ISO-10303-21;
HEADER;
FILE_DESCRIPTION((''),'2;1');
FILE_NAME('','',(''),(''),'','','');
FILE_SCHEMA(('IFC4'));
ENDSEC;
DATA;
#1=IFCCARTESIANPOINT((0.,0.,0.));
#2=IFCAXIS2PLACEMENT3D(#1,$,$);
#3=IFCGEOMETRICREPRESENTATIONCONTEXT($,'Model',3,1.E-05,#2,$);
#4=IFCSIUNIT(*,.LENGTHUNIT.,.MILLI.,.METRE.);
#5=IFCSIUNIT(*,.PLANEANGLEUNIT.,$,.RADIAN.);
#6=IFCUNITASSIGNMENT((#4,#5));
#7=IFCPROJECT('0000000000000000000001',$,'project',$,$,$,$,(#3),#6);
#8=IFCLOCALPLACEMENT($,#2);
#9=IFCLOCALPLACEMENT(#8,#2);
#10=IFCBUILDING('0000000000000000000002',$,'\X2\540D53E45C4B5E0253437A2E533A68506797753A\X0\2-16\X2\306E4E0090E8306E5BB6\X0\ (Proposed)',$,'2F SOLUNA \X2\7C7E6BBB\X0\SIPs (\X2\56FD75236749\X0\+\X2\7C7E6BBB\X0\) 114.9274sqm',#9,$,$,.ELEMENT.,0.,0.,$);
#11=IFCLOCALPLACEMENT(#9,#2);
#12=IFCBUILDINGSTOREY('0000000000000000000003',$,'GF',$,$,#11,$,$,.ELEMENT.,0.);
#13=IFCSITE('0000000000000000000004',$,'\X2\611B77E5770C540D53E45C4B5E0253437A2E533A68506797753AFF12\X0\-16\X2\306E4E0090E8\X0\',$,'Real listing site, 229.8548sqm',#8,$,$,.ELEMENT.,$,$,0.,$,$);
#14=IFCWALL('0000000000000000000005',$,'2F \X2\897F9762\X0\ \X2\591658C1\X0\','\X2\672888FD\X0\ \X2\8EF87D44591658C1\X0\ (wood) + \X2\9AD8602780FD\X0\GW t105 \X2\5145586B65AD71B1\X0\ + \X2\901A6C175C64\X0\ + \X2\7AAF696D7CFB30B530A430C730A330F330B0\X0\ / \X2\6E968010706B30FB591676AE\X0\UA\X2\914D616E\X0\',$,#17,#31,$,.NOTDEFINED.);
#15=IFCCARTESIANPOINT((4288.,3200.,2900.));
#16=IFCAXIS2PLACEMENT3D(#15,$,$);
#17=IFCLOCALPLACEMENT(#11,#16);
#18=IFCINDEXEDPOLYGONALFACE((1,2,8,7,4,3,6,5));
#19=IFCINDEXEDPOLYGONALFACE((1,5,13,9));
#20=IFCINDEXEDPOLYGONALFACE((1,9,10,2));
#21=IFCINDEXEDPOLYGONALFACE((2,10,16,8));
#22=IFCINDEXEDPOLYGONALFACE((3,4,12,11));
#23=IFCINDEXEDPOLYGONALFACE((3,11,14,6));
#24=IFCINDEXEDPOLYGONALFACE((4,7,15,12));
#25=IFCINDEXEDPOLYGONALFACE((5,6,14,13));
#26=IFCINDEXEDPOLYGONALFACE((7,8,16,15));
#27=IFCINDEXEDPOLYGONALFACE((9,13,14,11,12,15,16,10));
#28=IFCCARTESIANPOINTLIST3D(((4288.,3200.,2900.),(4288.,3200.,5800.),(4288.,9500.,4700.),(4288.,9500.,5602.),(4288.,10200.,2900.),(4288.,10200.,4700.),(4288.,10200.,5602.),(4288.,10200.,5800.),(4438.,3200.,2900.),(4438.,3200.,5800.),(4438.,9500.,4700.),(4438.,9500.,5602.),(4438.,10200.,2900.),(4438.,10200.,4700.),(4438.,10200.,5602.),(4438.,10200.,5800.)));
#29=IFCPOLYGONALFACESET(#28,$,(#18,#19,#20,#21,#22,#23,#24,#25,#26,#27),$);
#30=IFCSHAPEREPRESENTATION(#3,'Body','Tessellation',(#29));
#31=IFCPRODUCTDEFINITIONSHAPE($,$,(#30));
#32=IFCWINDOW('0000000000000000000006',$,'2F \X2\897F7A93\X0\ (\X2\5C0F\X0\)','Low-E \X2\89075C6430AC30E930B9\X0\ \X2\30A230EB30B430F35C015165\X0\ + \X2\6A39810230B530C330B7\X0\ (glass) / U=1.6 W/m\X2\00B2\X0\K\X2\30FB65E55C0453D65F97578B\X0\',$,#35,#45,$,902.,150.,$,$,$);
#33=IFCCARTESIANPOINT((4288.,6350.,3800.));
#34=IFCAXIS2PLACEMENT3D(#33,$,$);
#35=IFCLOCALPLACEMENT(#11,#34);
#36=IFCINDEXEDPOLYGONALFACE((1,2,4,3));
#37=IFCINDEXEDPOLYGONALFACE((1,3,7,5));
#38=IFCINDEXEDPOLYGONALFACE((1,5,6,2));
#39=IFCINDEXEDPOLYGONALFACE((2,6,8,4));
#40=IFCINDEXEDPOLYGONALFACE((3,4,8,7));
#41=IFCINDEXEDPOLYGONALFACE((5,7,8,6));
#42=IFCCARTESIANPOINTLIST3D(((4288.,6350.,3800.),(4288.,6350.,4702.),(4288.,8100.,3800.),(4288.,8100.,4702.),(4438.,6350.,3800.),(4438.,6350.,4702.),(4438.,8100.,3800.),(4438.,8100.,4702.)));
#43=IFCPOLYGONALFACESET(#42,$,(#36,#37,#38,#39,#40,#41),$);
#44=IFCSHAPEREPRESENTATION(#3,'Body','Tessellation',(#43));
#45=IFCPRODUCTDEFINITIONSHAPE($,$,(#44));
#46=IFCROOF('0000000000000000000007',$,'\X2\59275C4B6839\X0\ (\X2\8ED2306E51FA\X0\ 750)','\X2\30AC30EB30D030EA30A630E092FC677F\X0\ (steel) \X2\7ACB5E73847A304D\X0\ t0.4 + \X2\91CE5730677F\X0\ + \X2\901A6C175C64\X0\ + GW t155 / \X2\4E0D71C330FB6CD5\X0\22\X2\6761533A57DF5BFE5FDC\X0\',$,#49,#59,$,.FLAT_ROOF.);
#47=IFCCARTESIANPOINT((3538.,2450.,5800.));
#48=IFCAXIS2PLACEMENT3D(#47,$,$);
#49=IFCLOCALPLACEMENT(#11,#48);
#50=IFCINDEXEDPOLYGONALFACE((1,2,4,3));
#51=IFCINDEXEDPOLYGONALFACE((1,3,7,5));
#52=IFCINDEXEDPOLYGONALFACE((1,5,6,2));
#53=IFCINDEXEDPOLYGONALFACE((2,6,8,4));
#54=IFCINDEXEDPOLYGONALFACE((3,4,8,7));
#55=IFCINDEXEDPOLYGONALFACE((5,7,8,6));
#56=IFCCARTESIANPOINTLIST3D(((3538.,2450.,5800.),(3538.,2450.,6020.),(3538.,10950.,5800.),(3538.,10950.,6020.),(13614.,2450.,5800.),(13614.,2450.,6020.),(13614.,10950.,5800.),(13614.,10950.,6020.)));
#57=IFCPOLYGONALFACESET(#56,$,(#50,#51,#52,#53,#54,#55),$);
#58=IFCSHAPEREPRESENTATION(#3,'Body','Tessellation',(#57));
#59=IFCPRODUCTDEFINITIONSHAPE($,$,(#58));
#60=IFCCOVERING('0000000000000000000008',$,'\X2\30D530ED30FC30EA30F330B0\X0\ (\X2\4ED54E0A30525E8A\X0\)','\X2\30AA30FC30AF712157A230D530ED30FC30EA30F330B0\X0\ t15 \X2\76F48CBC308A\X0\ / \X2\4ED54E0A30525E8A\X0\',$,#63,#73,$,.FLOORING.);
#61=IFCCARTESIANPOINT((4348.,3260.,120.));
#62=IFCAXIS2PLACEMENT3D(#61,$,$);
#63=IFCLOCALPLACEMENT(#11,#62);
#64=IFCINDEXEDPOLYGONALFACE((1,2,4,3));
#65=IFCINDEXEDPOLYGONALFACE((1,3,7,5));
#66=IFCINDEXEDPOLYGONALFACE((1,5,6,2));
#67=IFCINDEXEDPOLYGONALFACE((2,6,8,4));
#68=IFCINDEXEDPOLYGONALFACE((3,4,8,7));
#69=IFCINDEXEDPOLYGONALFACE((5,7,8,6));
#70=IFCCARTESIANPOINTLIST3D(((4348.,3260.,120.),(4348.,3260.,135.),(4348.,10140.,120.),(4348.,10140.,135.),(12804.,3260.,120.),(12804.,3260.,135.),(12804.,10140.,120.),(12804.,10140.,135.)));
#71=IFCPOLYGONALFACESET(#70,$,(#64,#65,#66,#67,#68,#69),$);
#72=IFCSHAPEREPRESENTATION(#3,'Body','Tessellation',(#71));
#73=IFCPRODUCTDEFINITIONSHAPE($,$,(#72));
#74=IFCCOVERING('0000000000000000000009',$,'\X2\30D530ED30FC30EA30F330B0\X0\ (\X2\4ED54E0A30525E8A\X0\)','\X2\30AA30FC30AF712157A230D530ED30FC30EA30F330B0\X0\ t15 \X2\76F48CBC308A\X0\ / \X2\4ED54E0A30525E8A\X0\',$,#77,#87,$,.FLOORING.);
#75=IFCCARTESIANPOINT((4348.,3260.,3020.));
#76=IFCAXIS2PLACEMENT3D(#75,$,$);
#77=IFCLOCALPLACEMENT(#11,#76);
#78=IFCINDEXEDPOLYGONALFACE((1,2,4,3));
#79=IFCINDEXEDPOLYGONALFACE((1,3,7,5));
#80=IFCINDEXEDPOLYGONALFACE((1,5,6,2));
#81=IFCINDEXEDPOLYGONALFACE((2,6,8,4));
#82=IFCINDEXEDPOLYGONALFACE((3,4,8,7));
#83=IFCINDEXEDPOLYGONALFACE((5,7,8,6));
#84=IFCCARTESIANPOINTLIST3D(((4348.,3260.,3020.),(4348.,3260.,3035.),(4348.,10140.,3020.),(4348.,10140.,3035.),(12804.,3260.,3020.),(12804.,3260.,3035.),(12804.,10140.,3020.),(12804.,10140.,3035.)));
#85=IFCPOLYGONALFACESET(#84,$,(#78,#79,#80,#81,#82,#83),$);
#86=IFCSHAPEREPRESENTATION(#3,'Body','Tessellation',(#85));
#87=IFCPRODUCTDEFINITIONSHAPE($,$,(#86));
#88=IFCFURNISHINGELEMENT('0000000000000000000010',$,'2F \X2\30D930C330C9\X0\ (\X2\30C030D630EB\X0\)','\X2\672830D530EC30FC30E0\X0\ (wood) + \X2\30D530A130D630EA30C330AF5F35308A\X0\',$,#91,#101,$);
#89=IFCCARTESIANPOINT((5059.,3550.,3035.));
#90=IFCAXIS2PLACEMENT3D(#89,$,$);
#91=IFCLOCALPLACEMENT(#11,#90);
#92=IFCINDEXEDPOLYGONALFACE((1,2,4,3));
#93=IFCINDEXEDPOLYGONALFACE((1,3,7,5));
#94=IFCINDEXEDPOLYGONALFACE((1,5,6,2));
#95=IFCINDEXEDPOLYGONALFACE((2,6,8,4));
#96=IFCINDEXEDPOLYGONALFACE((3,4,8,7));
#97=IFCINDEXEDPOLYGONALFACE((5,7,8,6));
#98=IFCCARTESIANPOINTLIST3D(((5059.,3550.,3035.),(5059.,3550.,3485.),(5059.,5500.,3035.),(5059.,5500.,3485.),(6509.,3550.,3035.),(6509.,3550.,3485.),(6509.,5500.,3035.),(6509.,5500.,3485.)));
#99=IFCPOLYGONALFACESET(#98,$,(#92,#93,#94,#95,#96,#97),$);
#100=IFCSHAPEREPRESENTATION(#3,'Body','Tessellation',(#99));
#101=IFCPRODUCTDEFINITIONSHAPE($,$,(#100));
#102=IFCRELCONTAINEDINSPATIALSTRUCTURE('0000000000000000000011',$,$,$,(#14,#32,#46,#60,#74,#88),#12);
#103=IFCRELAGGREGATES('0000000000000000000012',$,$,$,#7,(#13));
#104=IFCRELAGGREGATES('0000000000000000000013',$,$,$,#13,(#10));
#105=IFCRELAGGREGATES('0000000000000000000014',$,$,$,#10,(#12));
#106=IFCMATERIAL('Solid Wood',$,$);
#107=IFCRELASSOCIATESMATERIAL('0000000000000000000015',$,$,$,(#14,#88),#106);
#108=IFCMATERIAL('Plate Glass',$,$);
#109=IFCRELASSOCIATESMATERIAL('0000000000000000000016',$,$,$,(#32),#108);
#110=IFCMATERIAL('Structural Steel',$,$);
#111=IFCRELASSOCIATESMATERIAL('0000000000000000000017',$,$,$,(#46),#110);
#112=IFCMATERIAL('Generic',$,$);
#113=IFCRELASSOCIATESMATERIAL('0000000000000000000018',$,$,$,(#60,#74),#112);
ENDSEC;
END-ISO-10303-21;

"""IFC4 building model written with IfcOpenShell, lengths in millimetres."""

from ifc_helpers import new_model, si_unit, frame, frame_2d, origin, place, context, project, spatial, rectangle, extrude, material, element, fill, save


model = new_model("IFC4")

# Units and contexts
model_context = context("Model", 3, precision=1e-05, world=origin())
ifc_project = project(units=[si_unit("LENGTHUNIT", "METRE", prefix="MILLI"), si_unit("PLANEANGLEUNIT", "RADIAN")], contexts=[model_context])

# Site, building, storey
site_placement = place(None, origin())
site = spatial("IfcSite", under=ifc_project, at=site_placement, Name="愛知県名古屋市千種区桐林町２-16の一部", ObjectType="Real listing site, 229.8548sqm", CompositionType="ELEMENT", RefElevation=0.0)
building_placement = place(site_placement, origin())
building = spatial("IfcBuilding", under=site, at=building_placement, Name="名古屋市千種区桐林町2-16の一部の家 (Proposed)", ObjectType="2F SOLUNA 籾殻SIPs (国産杉+籾殻) 114.9274sqm", CompositionType="ELEMENT", ElevationOfRefHeight=0.0, ElevationOfTerrain=0.0)
storey_placement = place(building_placement, origin())
storey = spatial("IfcBuildingStorey", under=building, at=storey_placement, Name="GF", CompositionType="ELEMENT", Elevation=0.0)

# Shared definitions
ifc_material_1 = material(Name="Solid Wood")

# Shared definitions
ifc_material_2 = material(Name="Plate Glass")

# Wall, opening, window
wall_1_placement = place(storey_placement, frame((4288.0, 3200.0, 2900.0)))
wall_1 = element("IfcWall", 1, at=wall_1_placement, inside=storey, material=ifc_material_1, Name="2F 西面 外壁", Description="木製 軸組外壁 (wood) + 高性能GW t105 充填断熱 + 通気層 + 窯業系サイディング / 準耐火・外皮UA配慮", PredefinedType="NOTDEFINED", context=model_context, shape_type="SweptSolid", body=[
    extrude(rectangle(XDim=150.0, YDim=7000.0, at=frame_2d((75.0, 3500.0))), frame((4288.0, 3200.0, 2900.0)), (0.0, 0.0, 1.0), 2900.0),
])
opening_1_placement = place(storey_placement, frame((4288.0, 6350.0, 3800.0)))
opening_1 = element("IfcOpeningElement", 2, at=opening_1_placement, cuts=wall_1, PredefinedType="NOTDEFINED", context=model_context, shape_type="SweptSolid", body=[
    extrude(rectangle(XDim=150.0, YDim=1750.0, at=frame_2d((75.0, 875.0))), frame((4288.0, 6350.0, 3800.0)), (0.0, 0.0, 1.0), 902.0),
])
window_1_placement = place(storey_placement, frame((4288.0, 6350.0, 3800.0)))
window_1 = element("IfcWindow", 3, at=window_1_placement, inside=storey, material=ifc_material_2, Name="2F 西窓 (小)", Description="Low-E 複層ガラス アルゴン封入 + 樹脂サッシ (glass) / U=1.6 W/m²K・日射取得型", OverallHeight=902.0, OverallWidth=150.0, context=model_context, shape_type="SweptSolid", body=[
    extrude(rectangle(XDim=150.0, YDim=1750.0, at=frame_2d((75.0, 875.0))), frame((4288.0, 6350.0, 3800.0)), (0.0, 0.0, 1.0), 902.0),
])
fill(opening_1, window_1)

# Roof
ifc_material_3 = material(Name="Structural Steel")
roof_placement = place(storey_placement, frame((3538.0, 2450.0, 5800.0)))
element("IfcRoof", 4, at=roof_placement, inside=storey, material=ifc_material_3, Name="大屋根 (軒の出 750)", Description="ガルバリウム鋼板 (steel) 立平葺き t0.4 + 野地板 + 通気層 + GW t155 / 不燃・法22条区域対応", PredefinedType="FLAT_ROOF", context=model_context, shape_type="SweptSolid", body=[
    extrude(rectangle(XDim=10076.0, YDim=8500.0, at=frame_2d((5038.0, 4250.0))), frame((3538.0, 2450.0, 5800.0)), (0.0, 0.0, 1.0), 220.0),
])

# Coverings
ifc_material_4 = material(Name="Generic")
covering_1_placement = place(storey_placement, frame((4348.0, 3260.0, 120.0)))
element("IfcCovering", 5, at=covering_1_placement, inside=storey, material=ifc_material_4, Name="フローリング (仕上げ床)", Description="オーク無垢フローリング t15 直貼り / 仕上げ床", PredefinedType="FLOORING", context=model_context, shape_type="SweptSolid", body=[
    extrude(rectangle(XDim=8456.0, YDim=6880.0, at=frame_2d((4228.0, 3440.0))), frame((4348.0, 3260.0, 120.0)), (0.0, 0.0, 1.0), 15.0),
])
covering_2_placement = place(storey_placement, frame((4348.0, 3260.0, 3020.0)))
element("IfcCovering", 6, at=covering_2_placement, inside=storey, material=ifc_material_4, Name="フローリング (仕上げ床)", Description="オーク無垢フローリング t15 直貼り / 仕上げ床", PredefinedType="FLOORING", context=model_context, shape_type="SweptSolid", body=[
    extrude(rectangle(XDim=8456.0, YDim=6880.0, at=frame_2d((4228.0, 3440.0))), frame((4348.0, 3260.0, 3020.0)), (0.0, 0.0, 1.0), 15.0),
])

# Furnishing element
furnishing_placement = place(storey_placement, frame((5059.0, 3550.0, 3035.0)))
element("IfcFurnishingElement", 7, at=furnishing_placement, inside=storey, material=ifc_material_1, Name="2F ベッド (ダブル)", Description="木フレーム (wood) + ファブリック張り", context=model_context, shape_type="SweptSolid", body=[
    extrude(rectangle(XDim=1450.0, YDim=1950.0, at=frame_2d((725.0, 975.0))), frame((5059.0, 3550.0, 3035.0)), (0.0, 0.0, 1.0), 450.0),
])

save(model, "model.ifc")
